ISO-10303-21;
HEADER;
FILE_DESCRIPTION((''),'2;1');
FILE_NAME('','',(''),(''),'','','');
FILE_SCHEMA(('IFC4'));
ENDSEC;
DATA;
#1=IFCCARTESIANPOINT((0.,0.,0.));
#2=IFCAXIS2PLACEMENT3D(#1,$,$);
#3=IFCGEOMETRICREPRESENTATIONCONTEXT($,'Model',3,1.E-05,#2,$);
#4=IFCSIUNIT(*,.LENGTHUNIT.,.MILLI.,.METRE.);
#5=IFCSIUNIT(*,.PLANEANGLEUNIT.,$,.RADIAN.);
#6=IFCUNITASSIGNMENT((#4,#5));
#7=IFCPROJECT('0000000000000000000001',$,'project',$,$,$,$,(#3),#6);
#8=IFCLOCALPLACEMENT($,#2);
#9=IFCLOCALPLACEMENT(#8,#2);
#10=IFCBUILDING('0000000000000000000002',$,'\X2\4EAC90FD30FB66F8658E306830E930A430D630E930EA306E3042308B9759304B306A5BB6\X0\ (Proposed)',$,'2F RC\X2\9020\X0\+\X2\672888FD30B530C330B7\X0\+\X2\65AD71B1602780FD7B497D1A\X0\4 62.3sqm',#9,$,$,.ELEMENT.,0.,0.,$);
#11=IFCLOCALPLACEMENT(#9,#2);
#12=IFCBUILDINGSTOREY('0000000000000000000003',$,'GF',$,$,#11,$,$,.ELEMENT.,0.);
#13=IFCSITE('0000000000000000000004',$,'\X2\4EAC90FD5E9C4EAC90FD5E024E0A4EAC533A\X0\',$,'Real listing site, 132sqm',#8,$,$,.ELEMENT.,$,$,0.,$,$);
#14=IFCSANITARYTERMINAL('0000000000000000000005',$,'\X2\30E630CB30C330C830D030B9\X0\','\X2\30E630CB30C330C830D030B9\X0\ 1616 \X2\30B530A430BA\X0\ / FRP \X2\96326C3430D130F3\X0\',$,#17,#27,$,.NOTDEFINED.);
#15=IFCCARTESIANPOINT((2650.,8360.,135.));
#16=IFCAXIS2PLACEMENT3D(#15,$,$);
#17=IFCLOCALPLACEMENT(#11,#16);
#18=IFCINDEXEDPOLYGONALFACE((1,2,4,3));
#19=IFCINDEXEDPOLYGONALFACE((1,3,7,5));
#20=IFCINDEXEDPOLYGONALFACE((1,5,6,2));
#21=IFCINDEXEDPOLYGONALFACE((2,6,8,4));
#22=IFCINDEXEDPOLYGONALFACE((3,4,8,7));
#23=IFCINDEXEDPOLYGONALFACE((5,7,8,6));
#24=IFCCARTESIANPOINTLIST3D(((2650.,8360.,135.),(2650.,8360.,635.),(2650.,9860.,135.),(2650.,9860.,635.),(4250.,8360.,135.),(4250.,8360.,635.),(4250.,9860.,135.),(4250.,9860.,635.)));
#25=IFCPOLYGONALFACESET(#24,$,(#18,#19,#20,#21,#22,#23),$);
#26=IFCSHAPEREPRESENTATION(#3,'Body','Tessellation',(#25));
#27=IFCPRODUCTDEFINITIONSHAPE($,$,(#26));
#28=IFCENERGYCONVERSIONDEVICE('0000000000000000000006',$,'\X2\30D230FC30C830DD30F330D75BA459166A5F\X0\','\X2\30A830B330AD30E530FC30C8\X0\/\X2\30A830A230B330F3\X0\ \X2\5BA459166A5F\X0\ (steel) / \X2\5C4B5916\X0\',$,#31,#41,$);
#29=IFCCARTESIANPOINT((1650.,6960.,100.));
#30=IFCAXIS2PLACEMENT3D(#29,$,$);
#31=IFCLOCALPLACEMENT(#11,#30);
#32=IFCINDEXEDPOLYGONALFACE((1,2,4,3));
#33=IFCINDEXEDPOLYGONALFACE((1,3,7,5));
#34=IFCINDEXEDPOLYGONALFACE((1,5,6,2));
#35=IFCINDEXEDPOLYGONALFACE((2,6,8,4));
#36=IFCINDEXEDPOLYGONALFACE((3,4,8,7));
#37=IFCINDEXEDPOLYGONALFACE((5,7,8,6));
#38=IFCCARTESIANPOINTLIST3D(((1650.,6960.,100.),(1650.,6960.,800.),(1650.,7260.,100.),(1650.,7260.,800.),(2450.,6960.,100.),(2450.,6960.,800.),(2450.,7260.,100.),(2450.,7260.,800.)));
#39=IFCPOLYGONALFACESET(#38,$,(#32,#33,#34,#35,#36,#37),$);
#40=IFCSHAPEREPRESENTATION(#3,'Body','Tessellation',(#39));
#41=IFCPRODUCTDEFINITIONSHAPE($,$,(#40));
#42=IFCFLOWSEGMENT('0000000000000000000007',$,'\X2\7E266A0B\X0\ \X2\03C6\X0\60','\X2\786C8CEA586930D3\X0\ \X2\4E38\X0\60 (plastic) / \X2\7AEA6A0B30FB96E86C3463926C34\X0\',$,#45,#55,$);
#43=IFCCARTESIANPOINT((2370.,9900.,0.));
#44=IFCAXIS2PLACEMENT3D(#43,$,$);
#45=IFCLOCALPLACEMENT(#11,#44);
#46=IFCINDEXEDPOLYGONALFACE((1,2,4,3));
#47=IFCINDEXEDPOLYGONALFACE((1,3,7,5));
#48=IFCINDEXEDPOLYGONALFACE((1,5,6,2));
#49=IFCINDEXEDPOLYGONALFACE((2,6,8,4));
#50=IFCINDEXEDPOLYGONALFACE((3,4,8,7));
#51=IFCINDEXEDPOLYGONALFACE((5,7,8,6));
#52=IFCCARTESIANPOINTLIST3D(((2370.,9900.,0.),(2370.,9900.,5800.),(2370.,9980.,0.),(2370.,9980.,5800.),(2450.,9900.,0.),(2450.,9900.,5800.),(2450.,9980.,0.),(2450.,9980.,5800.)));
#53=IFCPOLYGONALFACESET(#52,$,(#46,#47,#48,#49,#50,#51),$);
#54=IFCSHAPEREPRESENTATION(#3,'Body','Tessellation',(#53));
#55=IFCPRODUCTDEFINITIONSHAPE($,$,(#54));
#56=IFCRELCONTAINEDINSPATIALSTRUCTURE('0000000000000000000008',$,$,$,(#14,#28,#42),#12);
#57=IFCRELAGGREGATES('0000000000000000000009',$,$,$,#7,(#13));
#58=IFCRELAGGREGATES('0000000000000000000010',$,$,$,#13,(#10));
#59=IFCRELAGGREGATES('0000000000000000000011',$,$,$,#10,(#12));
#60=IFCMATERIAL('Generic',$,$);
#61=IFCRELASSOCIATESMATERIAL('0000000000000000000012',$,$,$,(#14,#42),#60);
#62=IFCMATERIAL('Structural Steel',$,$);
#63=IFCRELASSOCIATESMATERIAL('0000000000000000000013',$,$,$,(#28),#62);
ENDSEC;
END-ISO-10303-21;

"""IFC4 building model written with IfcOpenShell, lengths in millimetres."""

from ifc_helpers import new_model, si_unit, frame, frame_2d, origin, place, context, project, spatial, rectangle, extrude, material, element, save


model = new_model("IFC4")

# Units and contexts
model_context = context("Model", 3, precision=1e-05, world=origin())
ifc_project = project(units=[si_unit("LENGTHUNIT", "METRE", prefix="MILLI"), si_unit("PLANEANGLEUNIT", "RADIAN")], contexts=[model_context])

# Site, building, storey
site_placement = place(None, origin())
site = spatial("IfcSite", under=ifc_project, at=site_placement, Name="京都府京都市上京区", ObjectType="Real listing site, 132sqm", CompositionType="ELEMENT", RefElevation=0.0)
building_placement = place(site_placement, origin())
building = spatial("IfcBuilding", under=site, at=building_placement, Name="京都・書斎とライブラリのある静かな家 (Proposed)", ObjectType="2F RC造+木製サッシ+断熱性能等級4 62.3sqm", CompositionType="ELEMENT", ElevationOfRefHeight=0.0, ElevationOfTerrain=0.0)
storey_placement = place(building_placement, origin())
storey = spatial("IfcBuildingStorey", under=building, at=storey_placement, Name="GF", CompositionType="ELEMENT", Elevation=0.0)

# Shared definitions
ifc_material_1 = material(Name="Generic")

# Sanitary terminal
sanitary_terminal_placement = place(storey_placement, frame((2650.0, 8360.0, 135.0)))
element("IfcSanitaryTerminal", 1, at=sanitary_terminal_placement, inside=storey, material=ifc_material_1, Name="ユニットバス", Description="ユニットバス 1616 サイズ / FRP 防水パン", PredefinedType="NOTDEFINED", context=model_context, shape_type="SweptSolid", body=[
    extrude(rectangle(XDim=1600.0, YDim=1500.0, at=frame_2d((800.0, 750.0))), frame((2650.0, 8360.0, 135.0)), (0.0, 0.0, 1.0), 500.0),
])

# Energy conversion device
ifc_material_2 = material(Name="Structural Steel")
energy_conversion_device_placement = place(storey_placement, frame((1650.0, 6960.0, 100.0)))
element("IfcEnergyConversionDevice", 2, at=energy_conversion_device_placement, inside=storey, material=ifc_material_2, Name="ヒートポンプ室外機", Description="エコキュート/エアコン 室外機 (steel) / 屋外", context=model_context, shape_type="SweptSolid", body=[
    extrude(rectangle(XDim=800.0, YDim=300.0, at=frame_2d((400.0, 150.0))), frame((1650.0, 6960.0, 100.0)), (0.0, 0.0, 1.0), 700.0),
])

# Flow segment
flow_segment_placement = place(storey_placement, frame((2370.0, 9900.0, 0.0)))
element("IfcFlowSegment", 3, at=flow_segment_placement, inside=storey, material=ifc_material_1, Name="縦樋 φ60", Description="硬質塩ビ 丸60 (plastic) / 竪樋・雨水排水", context=model_context, shape_type="SweptSolid", body=[
    extrude(rectangle(XDim=80.0, YDim=80.0, at=frame_2d((40.0, 40.0))), frame((2370.0, 9900.0, 0.0)), (0.0, 0.0, 1.0), 5800.0),
])

save(model, "model.ifc")
